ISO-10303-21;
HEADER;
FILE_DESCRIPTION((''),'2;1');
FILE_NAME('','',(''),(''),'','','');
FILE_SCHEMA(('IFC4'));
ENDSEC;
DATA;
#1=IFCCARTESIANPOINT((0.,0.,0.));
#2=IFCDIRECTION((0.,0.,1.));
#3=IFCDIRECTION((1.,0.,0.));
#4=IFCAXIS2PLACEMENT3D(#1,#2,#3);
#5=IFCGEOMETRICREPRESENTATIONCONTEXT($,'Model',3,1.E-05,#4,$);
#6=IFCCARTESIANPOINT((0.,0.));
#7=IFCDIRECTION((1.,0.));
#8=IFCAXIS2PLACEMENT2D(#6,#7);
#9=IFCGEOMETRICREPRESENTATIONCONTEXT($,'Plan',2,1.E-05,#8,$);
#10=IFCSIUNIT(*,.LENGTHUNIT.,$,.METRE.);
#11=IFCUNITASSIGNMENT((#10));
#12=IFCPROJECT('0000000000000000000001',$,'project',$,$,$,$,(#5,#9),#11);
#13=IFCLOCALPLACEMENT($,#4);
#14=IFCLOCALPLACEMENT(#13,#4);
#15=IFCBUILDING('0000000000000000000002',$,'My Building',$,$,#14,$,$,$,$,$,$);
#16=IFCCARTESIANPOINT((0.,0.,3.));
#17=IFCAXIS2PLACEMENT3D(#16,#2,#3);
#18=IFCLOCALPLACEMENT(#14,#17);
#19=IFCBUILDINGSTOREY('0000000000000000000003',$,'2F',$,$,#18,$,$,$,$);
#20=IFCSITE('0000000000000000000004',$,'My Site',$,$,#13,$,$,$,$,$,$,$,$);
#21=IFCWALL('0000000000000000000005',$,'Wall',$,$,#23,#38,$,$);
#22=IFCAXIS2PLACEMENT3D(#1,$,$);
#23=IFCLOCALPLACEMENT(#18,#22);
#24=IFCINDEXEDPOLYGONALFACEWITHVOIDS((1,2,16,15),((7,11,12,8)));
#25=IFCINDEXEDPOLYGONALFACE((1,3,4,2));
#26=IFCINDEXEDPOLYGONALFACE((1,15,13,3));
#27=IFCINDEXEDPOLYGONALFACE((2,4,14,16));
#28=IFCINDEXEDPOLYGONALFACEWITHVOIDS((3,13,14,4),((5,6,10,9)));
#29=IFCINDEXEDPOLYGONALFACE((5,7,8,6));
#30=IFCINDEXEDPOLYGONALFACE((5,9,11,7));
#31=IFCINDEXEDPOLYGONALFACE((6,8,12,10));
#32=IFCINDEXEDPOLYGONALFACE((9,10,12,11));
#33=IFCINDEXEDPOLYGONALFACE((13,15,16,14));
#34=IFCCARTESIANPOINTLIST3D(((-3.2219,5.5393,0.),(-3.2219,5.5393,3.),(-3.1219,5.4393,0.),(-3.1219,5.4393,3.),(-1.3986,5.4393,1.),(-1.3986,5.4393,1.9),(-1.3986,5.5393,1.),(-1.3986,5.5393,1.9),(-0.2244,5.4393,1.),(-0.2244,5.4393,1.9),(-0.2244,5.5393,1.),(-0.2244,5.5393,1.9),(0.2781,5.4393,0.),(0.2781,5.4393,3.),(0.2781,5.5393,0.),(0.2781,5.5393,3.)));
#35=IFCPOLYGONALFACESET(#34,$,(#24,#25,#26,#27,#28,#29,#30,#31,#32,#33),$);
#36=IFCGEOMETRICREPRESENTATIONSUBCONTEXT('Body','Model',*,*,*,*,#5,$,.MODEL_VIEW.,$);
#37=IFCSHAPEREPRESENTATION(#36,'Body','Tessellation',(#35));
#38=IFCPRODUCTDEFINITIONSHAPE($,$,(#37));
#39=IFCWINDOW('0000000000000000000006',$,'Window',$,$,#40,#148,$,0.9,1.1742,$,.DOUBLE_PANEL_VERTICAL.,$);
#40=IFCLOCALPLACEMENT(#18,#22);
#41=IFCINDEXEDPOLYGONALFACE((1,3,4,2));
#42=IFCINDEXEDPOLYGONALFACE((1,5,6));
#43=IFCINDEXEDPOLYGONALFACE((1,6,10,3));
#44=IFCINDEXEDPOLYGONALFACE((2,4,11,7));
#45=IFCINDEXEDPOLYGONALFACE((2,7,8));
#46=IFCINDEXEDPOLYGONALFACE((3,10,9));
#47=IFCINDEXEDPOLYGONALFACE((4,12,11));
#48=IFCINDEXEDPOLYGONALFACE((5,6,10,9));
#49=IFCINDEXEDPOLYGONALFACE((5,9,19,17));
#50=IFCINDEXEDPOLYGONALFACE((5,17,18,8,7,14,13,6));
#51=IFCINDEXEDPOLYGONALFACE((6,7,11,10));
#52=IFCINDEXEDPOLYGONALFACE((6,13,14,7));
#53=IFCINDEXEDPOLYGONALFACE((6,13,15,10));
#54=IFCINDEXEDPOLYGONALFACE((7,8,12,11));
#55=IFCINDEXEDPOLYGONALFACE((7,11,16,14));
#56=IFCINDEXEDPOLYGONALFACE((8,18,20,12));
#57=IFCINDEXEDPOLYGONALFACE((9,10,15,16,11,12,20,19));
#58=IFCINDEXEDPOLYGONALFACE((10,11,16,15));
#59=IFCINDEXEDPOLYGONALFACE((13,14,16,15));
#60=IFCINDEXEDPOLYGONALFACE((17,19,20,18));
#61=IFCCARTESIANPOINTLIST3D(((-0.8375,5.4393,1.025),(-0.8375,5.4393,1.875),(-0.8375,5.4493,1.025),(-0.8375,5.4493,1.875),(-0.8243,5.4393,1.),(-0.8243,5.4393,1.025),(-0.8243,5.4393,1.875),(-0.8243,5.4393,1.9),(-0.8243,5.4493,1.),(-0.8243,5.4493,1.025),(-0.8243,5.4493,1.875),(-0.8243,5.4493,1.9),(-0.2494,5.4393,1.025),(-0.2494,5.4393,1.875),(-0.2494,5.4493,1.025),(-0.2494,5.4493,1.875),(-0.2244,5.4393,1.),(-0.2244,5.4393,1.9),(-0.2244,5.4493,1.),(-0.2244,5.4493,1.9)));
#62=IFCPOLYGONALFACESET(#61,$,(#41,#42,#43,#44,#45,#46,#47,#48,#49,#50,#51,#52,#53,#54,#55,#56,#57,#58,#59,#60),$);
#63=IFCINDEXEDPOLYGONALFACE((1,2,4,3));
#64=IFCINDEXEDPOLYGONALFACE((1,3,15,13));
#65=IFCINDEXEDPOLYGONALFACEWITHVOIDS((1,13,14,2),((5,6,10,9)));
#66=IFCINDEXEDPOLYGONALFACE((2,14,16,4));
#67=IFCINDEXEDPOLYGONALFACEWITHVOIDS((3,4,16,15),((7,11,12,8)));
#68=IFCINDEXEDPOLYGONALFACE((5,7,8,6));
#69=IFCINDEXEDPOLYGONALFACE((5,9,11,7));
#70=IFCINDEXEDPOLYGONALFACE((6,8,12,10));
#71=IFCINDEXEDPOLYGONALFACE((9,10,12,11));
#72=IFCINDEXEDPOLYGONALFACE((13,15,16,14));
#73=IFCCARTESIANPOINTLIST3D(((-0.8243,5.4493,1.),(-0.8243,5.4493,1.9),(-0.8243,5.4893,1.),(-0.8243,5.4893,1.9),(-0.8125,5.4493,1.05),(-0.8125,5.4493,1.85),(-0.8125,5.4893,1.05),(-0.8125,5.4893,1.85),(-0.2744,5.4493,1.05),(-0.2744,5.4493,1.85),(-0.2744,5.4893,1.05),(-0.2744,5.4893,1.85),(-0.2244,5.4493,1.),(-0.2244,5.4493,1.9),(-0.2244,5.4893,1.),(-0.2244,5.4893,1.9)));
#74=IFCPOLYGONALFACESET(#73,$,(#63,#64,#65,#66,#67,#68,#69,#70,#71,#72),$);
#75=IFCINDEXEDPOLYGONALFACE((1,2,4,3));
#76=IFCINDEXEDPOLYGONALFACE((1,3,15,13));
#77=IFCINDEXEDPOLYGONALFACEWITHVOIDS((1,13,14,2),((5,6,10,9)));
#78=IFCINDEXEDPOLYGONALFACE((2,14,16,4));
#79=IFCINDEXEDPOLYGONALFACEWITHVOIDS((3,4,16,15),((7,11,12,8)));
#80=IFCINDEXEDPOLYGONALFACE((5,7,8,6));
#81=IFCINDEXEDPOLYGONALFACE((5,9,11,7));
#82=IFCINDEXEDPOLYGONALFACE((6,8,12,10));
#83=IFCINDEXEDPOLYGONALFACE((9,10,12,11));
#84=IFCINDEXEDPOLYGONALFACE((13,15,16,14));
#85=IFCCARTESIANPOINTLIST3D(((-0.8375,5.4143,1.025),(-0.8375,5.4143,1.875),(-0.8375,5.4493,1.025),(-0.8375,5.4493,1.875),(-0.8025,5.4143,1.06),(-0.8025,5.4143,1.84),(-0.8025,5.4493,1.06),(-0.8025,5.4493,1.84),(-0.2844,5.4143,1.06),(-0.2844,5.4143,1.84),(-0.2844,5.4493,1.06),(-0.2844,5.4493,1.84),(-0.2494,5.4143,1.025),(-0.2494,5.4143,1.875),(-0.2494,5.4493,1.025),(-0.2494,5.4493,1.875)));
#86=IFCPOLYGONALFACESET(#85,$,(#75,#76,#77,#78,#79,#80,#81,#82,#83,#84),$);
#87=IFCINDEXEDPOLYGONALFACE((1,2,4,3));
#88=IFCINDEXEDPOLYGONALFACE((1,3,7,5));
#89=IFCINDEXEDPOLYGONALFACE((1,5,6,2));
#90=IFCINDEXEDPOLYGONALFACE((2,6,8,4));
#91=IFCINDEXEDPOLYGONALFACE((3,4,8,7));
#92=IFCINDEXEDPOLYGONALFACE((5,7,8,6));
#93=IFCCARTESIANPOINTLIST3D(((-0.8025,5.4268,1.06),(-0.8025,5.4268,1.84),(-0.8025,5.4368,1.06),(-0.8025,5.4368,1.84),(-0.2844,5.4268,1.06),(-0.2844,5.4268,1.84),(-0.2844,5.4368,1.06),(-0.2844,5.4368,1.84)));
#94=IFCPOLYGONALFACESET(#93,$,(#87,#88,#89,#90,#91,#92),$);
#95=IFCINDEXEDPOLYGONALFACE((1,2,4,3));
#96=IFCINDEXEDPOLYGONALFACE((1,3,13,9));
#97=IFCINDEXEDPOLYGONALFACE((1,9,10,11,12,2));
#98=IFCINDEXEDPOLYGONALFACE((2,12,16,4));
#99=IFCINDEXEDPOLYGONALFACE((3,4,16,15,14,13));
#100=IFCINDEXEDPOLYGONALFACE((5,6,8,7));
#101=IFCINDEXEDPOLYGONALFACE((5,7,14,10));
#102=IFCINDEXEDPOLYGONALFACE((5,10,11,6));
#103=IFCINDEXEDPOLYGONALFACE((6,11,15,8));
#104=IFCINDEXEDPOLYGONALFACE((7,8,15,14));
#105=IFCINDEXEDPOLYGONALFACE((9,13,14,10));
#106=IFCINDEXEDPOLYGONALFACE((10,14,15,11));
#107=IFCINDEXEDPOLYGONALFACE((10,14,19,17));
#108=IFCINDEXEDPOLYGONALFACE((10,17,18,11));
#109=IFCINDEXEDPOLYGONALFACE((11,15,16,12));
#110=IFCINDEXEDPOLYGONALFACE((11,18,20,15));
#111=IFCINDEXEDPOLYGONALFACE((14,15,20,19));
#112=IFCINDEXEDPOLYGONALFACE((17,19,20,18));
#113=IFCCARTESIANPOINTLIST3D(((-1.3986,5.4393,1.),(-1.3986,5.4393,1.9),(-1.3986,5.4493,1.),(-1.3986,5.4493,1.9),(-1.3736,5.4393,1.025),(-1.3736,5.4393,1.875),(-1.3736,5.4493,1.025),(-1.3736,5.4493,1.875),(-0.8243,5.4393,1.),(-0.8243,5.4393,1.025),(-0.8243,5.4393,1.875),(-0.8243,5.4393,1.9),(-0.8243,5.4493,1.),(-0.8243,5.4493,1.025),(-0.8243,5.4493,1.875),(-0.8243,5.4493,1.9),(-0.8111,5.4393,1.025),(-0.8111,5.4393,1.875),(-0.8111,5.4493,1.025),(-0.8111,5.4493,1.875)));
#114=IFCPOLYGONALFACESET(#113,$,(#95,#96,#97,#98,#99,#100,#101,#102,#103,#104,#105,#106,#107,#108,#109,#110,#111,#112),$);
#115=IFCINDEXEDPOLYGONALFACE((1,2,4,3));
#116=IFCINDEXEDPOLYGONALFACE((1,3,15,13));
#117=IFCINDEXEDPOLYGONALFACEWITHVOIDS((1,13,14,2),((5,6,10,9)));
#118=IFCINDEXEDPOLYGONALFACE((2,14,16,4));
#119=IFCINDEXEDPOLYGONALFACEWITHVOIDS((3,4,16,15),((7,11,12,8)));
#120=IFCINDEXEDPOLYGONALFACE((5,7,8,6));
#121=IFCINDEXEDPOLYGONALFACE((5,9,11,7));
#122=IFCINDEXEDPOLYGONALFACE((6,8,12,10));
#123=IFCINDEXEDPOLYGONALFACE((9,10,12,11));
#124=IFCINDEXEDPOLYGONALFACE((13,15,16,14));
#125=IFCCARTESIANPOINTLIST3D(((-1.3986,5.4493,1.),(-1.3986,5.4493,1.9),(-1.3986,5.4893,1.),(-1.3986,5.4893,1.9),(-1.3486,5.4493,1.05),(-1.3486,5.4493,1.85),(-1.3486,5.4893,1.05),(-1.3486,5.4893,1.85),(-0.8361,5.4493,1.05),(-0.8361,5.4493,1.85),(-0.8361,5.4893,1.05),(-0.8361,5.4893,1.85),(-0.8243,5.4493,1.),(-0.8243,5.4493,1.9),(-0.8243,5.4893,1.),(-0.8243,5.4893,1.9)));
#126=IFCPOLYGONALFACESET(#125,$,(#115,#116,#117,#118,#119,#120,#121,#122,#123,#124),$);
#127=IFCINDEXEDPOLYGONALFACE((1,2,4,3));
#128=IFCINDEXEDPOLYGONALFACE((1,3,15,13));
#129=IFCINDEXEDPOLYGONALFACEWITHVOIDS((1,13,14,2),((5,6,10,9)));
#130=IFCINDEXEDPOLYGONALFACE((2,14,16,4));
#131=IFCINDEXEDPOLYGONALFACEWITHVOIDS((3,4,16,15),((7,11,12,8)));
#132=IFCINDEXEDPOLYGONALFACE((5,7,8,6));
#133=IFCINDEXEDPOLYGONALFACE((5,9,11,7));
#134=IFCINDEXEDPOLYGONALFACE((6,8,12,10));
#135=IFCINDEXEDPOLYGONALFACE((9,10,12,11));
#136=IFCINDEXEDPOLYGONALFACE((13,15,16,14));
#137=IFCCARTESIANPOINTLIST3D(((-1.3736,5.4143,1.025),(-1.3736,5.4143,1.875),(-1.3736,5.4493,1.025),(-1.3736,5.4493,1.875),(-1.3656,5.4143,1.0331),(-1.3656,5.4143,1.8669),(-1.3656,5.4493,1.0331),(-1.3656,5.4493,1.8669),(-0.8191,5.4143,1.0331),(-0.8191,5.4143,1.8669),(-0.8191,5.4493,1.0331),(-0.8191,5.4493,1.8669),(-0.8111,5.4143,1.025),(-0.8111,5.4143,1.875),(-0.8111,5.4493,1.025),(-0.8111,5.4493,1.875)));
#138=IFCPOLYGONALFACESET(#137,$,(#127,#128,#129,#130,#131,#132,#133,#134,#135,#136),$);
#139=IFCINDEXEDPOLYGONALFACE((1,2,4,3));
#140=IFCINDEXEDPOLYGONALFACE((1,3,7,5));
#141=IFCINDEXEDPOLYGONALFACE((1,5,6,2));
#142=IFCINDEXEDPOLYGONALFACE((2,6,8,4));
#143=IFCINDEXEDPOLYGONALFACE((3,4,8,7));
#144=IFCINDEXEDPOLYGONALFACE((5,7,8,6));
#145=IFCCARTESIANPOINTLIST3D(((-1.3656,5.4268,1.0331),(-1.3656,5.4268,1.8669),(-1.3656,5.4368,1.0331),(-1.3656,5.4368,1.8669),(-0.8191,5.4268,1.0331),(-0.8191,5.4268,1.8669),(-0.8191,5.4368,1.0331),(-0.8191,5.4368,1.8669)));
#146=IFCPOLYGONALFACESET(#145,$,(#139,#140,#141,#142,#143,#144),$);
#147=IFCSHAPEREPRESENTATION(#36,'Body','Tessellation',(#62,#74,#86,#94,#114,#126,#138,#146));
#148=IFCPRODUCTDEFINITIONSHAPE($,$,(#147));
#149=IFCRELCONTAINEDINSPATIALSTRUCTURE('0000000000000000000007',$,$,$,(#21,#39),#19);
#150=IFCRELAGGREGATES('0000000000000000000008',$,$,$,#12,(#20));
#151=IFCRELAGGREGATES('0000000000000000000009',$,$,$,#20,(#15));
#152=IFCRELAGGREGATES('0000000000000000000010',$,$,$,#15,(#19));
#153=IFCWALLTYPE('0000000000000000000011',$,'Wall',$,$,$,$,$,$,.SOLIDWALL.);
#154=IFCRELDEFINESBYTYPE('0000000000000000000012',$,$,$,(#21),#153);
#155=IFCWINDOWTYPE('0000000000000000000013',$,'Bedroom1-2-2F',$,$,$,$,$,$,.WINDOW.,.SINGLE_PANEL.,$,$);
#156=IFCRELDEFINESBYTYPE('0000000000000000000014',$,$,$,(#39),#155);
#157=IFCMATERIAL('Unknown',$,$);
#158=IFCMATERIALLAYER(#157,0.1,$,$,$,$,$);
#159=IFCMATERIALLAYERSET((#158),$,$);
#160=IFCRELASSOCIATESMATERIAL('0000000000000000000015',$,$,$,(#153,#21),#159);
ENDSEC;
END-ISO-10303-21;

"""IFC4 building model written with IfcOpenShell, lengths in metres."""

from ifc_helpers import new_model, entity, si_unit, frame, origin_with_axes, origin_2d_with_axis, place, context, subcontext, project, spatial, line, indexed_curve, outline, extrude, shape, source, transform, mapped, material, layer, layer_set, layer_usage, type_object, type_shapes, element, fill, save


model = new_model("IFC4")

# Units and contexts
model_context = context("Model", 3, precision=1e-05, world=origin_with_axes())
plan_context = context("Plan", 2, precision=1e-05, world=origin_2d_with_axis())
body_context_1 = subcontext(model_context, "Body", "Model", "MODEL_VIEW")
body_context_2 = subcontext(plan_context, "Body", "Plan", "PLAN_VIEW")
ifc_project = project(units=[si_unit("LENGTHUNIT", "METRE")], contexts=[model_context, plan_context])

# Site, building, storey
site_placement = place(None, origin_with_axes())
site = spatial("IfcSite", under=ifc_project, at=site_placement, Name="My Site")
building_placement = place(site_placement, origin_with_axes())
building = spatial("IfcBuilding", under=site, at=building_placement, Name="My Building")
storey_placement = place(building_placement, frame((0.0, 0.0, 3.0), z_axis=(0.0, 0.0, 1.0), x_axis=(1.0, 0.0, 0.0)))
storey = spatial("IfcBuildingStorey", under=building, at=storey_placement, Name="2F")

# Shared definitions
ifc_material = material(Name="Unknown")

# Shared definitions
ifc_layer = layer(ifc_material, 0.1)
ifc_layer_set = layer_set([ifc_layer])
wall_type = type_object("IfcWallType", Name="Wall", PredefinedType="SOLIDWALL", material=ifc_layer_set)

# Wall, opening, window
ifc_layer_usage_1 = layer_usage(ifc_layer_set, "AXIS2", "POSITIVE", 0.0)
wall_1_placement = place(storey_placement, frame((0.2781, 5.5393, 0.0), z_axis=(0.0, 0.0, 1.0), x_axis=(-1.0, 0.0, 0.0)))
wall_1 = element("IfcWall", 1, at=wall_1_placement, inside=storey, type_object=wall_type, material=ifc_layer_usage_1, Name="Wall", context=body_context_1, shape_type="SweptSolid", body=[
    extrude(outline(indexed_curve([(0.0, 0.0), (0.0, 0.1), (3.4, 0.1), (3.5, 0.0)], segments=[line(1, 2, 3, 4, 1)])), origin_with_axes(), (0.0, 0.0, 1.0), 3.0),
])
shared_shape_1 = source(origin_with_axes(), body_context_1, "Body", "SweptSolid", [
    extrude(outline(indexed_curve([(0.0, 0.0), (1.1742, 0.0), (1.1742, 0.9), (0.0, 0.9)], segments=[line(1, 2, 3, 4, 1)])), frame((0.0, -0.6, 0.0), z_axis=(0.0, -1.0, 0.0), x_axis=(1.0, 0.0, 0.0)), (0.0, 0.0, -1.0), 1.2),
])
opening_1_placement = place(wall_1_placement, frame((0.5025, 0.0, 1.0), z_axis=(0.0, 0.0, 1.0), x_axis=(1.0, 0.0, 0.0)))
opening_1 = element("IfcOpeningElement", 2, at=opening_1_placement, cuts=wall_1, PredefinedType="OPENING", context=body_context_1, shape_type="MappedRepresentation", body=[
    mapped(shared_shape_1, transform((0.0, 0.0, 0.0), x_axis=(1.0, 0.0, 0.0), y_axis=(0.0, 1.0, 0.0), z_axis=(0.0, 0.0, 1.0), scale=1.0)),
])
window_type_1 = type_object("IfcWindowType", Name="Bedroom1-2-2F", PartitioningType="SINGLE_PANEL", PredefinedType="WINDOW")
shared_shape_2 = source(origin_with_axes(), body_context_1, "Body", "SweptSolid", [
    extrude(outline(indexed_curve([(0.0, 0.0), (0.5999, 0.0), (0.5999, 0.9), (0.0, 0.9)], segments=[line(1, 2, 3, 4, 1)]), holes=[indexed_curve([(0.025, 0.025), (0.6131, 0.025), (0.6131, 0.875), (0.025, 0.875)], segments=[line(1, 2, 3, 4, 1)])]), frame((0.0, 0.09, 0.0), z_axis=(0.0, -1.0, 0.0), x_axis=(1.0, 0.0, 0.0)), (0.0, 0.0, -1.0), 0.01),
    extrude(outline(indexed_curve([(0.0, 0.0), (0.5999, 0.0), (0.5999, 0.9), (0.0, 0.9)], segments=[line(1, 2, 3, 4, 1)]), holes=[indexed_curve([(0.05, 0.05), (0.5881, 0.05), (0.5881, 0.85), (0.05, 0.85)], segments=[line(1, 2, 3, 4, 1)])]), frame((0.0, 0.05, 0.0), z_axis=(0.0, -1.0, 0.0), x_axis=(1.0, 0.0, 0.0)), (0.0, 0.0, -1.0), 0.04),
    extrude(outline(indexed_curve([(0.0, 0.0), (0.5881, 0.0), (0.5881, 0.85), (0.0, 0.85)], segments=[line(1, 2, 3, 4, 1)]), holes=[indexed_curve([(0.035, 0.035), (0.5531, 0.035), (0.5531, 0.815), (0.035, 0.815)], segments=[line(1, 2, 3, 4, 1)])]), frame((0.025, 0.09, 0.025), z_axis=(0.0, -1.0, 0.0), x_axis=(1.0, 0.0, 0.0)), (0.0, 0.0, -1.0), 0.035),
    extrude(outline(indexed_curve([(0.035, 0.035), (0.5531, 0.035), (0.5531, 0.815), (0.035, 0.815)], segments=[line(1, 2, 3, 4, 1)])), frame((0.025, 0.1025, 0.025), z_axis=(0.0, -1.0, 0.0), x_axis=(1.0, 0.0, 0.0)), (0.0, 0.0, -1.0), 0.01),
    extrude(outline(indexed_curve([(0.0, 0.0), (0.5744, 0.0), (0.5744, 0.9), (0.0, 0.9)], segments=[line(1, 2, 3, 4, 1)]), holes=[indexed_curve([(-0.0132, 0.025), (0.5494, 0.025), (0.5494, 0.875), (-0.0132, 0.875)], segments=[line(1, 2, 3, 4, 1)])]), frame((0.5999, 0.09, 0.0), z_axis=(0.0, -1.0, 0.0), x_axis=(1.0, 0.0, 0.0)), (0.0, 0.0, -1.0), 0.01),
    extrude(outline(indexed_curve([(0.0, 0.0), (0.5744, 0.0), (0.5744, 0.9), (0.0, 0.9)], segments=[line(1, 2, 3, 4, 1)]), holes=[indexed_curve([(0.0118, 0.05), (0.5244, 0.05), (0.5244, 0.85), (0.0118, 0.85)], segments=[line(1, 2, 3, 4, 1)])]), frame((0.5999, 0.05, 0.0), z_axis=(0.0, -1.0, 0.0), x_axis=(1.0, 0.0, 0.0)), (0.0, 0.0, -1.0), 0.04),
    extrude(outline(indexed_curve([(0.0, 0.0), (0.5626, 0.0), (0.5626, 0.85), (0.0, 0.85)], segments=[line(1, 2, 3, 4, 1)]), holes=[indexed_curve([(0.0081, 0.0081), (0.5545, 0.0081), (0.5545, 0.8419), (0.0081, 0.8419)], segments=[line(1, 2, 3, 4, 1)])]), frame((0.5866, 0.09, 0.025), z_axis=(0.0, -1.0, 0.0), x_axis=(1.0, 0.0, 0.0)), (0.0, 0.0, -1.0), 0.035),
    extrude(outline(indexed_curve([(0.0081, 0.0081), (0.5545, 0.0081), (0.5545, 0.8419), (0.0081, 0.8419)], segments=[line(1, 2, 3, 4, 1)])), frame((0.5866, 0.1025, 0.025), z_axis=(0.0, -1.0, 0.0), x_axis=(1.0, 0.0, 0.0)), (0.0, 0.0, -1.0), 0.01),
])
shared_shape_3 = source(origin_with_axes(), body_context_2, "Body", "Curve2D", [
    entity("IfcIndexedPolyCurve", entity("IfcCartesianPointList2D", [[0.05, 0.05], [0.5881, 0.05]])),
    entity("IfcIndexedPolyCurve", entity("IfcCartesianPointList2D", [[0.0, 0.1], [0.025, 0.1], [0.025, 0.09], [0.05, 0.09], [0.05, 0.05], [0.0, 0.05]]), [entity("IfcLineIndex", [1, 2, 3, 4, 5, 6, 1])]),
    entity("IfcIndexedPolyCurve", entity("IfcCartesianPointList2D", [[0.5999, 0.1], [0.6131, 0.1], [0.6131, 0.09], [0.5881, 0.09], [0.5881, 0.05], [0.5999, 0.05]])),
    entity("IfcIndexedPolyCurve", entity("IfcCartesianPointList2D", [[0.025, 0.09], [0.06, 0.09], [0.06, 0.125], [0.025, 0.125]]), [entity("IfcLineIndex", [1, 2, 3, 4, 1])]),
    entity("IfcIndexedPolyCurve", entity("IfcCartesianPointList2D", [[0.6131, 0.09], [0.5781, 0.09], [0.5781, 0.125], [0.6131, 0.125]]), [entity("IfcLineIndex", [1, 2, 3, 4, 1])]),
    entity("IfcIndexedPolyCurve", entity("IfcCartesianPointList2D", [[0.06, 0.09], [0.5781, 0.09]])),
    entity("IfcIndexedPolyCurve", entity("IfcCartesianPointList2D", [[0.06, 0.125], [0.5781, 0.125]])),
    entity("IfcIndexedPolyCurve", entity("IfcCartesianPointList2D", [[0.06, 0.1075], [0.5781, 0.1075]])),
    entity("IfcIndexedPolyCurve", entity("IfcCartesianPointList2D", [[0.6116, 0.05], [1.1242, 0.05]])),
    entity("IfcIndexedPolyCurve", entity("IfcCartesianPointList2D", [[0.5999, 0.1], [0.5866, 0.1], [0.5866, 0.09], [0.6116, 0.09], [0.6116, 0.05], [0.5999, 0.05]])),
    entity("IfcIndexedPolyCurve", entity("IfcCartesianPointList2D", [[1.1742, 0.1], [1.1492, 0.1], [1.1492, 0.09], [1.1242, 0.09], [1.1242, 0.05], [1.1742, 0.05]]), [entity("IfcLineIndex", [1, 2, 3, 4, 5, 6, 1])]),
    entity("IfcIndexedPolyCurve", entity("IfcCartesianPointList2D", [[0.5866, 0.09], [0.5947, 0.09], [0.5947, 0.125], [0.5866, 0.125]]), [entity("IfcLineIndex", [1, 2, 3, 4, 1])]),
    entity("IfcIndexedPolyCurve", entity("IfcCartesianPointList2D", [[1.1492, 0.09], [1.1412, 0.09], [1.1412, 0.125], [1.1492, 0.125]]), [entity("IfcLineIndex", [1, 2, 3, 4, 1])]),
    entity("IfcIndexedPolyCurve", entity("IfcCartesianPointList2D", [[0.5947, 0.09], [1.1412, 0.09]])),
    entity("IfcIndexedPolyCurve", entity("IfcCartesianPointList2D", [[0.5947, 0.125], [1.1412, 0.125]])),
    entity("IfcIndexedPolyCurve", entity("IfcCartesianPointList2D", [[0.5947, 0.1075], [1.1412, 0.1075]])),
])
type_shapes(window_type_1, [shared_shape_2, shared_shape_3])
window_1_placement = place(opening_1_placement, frame((0.0, 0.0, 0.0), z_axis=(0.0, 0.0, 1.0), x_axis=(1.0, 0.0, 0.0)))
window_1 = element("IfcWindow", 3, at=window_1_placement, inside=storey, type_object=window_type_1, Name="Window", OverallHeight=0.9, OverallWidth=1.1742, PartitioningType="DOUBLE_PANEL_VERTICAL", shapes=[
    shape(body_context_1, "Body", "MappedRepresentation", [mapped(shared_shape_2, transform((0.0, 0.0, 0.0), x_axis=(1.0, 0.0, 0.0), y_axis=(0.0, 1.0, 0.0), z_axis=(0.0, 0.0, 1.0), scale=1.0))]),
    shape(body_context_2, "Body", "MappedRepresentation", [mapped(shared_shape_3, transform((0.0, 0.0, 0.0), x_axis=(1.0, 0.0, 0.0), y_axis=(0.0, 1.0, 0.0), z_axis=(0.0, 0.0, 1.0), scale=1.0))]),
])
fill(opening_1, window_1)

save(model, "model.ifc")
